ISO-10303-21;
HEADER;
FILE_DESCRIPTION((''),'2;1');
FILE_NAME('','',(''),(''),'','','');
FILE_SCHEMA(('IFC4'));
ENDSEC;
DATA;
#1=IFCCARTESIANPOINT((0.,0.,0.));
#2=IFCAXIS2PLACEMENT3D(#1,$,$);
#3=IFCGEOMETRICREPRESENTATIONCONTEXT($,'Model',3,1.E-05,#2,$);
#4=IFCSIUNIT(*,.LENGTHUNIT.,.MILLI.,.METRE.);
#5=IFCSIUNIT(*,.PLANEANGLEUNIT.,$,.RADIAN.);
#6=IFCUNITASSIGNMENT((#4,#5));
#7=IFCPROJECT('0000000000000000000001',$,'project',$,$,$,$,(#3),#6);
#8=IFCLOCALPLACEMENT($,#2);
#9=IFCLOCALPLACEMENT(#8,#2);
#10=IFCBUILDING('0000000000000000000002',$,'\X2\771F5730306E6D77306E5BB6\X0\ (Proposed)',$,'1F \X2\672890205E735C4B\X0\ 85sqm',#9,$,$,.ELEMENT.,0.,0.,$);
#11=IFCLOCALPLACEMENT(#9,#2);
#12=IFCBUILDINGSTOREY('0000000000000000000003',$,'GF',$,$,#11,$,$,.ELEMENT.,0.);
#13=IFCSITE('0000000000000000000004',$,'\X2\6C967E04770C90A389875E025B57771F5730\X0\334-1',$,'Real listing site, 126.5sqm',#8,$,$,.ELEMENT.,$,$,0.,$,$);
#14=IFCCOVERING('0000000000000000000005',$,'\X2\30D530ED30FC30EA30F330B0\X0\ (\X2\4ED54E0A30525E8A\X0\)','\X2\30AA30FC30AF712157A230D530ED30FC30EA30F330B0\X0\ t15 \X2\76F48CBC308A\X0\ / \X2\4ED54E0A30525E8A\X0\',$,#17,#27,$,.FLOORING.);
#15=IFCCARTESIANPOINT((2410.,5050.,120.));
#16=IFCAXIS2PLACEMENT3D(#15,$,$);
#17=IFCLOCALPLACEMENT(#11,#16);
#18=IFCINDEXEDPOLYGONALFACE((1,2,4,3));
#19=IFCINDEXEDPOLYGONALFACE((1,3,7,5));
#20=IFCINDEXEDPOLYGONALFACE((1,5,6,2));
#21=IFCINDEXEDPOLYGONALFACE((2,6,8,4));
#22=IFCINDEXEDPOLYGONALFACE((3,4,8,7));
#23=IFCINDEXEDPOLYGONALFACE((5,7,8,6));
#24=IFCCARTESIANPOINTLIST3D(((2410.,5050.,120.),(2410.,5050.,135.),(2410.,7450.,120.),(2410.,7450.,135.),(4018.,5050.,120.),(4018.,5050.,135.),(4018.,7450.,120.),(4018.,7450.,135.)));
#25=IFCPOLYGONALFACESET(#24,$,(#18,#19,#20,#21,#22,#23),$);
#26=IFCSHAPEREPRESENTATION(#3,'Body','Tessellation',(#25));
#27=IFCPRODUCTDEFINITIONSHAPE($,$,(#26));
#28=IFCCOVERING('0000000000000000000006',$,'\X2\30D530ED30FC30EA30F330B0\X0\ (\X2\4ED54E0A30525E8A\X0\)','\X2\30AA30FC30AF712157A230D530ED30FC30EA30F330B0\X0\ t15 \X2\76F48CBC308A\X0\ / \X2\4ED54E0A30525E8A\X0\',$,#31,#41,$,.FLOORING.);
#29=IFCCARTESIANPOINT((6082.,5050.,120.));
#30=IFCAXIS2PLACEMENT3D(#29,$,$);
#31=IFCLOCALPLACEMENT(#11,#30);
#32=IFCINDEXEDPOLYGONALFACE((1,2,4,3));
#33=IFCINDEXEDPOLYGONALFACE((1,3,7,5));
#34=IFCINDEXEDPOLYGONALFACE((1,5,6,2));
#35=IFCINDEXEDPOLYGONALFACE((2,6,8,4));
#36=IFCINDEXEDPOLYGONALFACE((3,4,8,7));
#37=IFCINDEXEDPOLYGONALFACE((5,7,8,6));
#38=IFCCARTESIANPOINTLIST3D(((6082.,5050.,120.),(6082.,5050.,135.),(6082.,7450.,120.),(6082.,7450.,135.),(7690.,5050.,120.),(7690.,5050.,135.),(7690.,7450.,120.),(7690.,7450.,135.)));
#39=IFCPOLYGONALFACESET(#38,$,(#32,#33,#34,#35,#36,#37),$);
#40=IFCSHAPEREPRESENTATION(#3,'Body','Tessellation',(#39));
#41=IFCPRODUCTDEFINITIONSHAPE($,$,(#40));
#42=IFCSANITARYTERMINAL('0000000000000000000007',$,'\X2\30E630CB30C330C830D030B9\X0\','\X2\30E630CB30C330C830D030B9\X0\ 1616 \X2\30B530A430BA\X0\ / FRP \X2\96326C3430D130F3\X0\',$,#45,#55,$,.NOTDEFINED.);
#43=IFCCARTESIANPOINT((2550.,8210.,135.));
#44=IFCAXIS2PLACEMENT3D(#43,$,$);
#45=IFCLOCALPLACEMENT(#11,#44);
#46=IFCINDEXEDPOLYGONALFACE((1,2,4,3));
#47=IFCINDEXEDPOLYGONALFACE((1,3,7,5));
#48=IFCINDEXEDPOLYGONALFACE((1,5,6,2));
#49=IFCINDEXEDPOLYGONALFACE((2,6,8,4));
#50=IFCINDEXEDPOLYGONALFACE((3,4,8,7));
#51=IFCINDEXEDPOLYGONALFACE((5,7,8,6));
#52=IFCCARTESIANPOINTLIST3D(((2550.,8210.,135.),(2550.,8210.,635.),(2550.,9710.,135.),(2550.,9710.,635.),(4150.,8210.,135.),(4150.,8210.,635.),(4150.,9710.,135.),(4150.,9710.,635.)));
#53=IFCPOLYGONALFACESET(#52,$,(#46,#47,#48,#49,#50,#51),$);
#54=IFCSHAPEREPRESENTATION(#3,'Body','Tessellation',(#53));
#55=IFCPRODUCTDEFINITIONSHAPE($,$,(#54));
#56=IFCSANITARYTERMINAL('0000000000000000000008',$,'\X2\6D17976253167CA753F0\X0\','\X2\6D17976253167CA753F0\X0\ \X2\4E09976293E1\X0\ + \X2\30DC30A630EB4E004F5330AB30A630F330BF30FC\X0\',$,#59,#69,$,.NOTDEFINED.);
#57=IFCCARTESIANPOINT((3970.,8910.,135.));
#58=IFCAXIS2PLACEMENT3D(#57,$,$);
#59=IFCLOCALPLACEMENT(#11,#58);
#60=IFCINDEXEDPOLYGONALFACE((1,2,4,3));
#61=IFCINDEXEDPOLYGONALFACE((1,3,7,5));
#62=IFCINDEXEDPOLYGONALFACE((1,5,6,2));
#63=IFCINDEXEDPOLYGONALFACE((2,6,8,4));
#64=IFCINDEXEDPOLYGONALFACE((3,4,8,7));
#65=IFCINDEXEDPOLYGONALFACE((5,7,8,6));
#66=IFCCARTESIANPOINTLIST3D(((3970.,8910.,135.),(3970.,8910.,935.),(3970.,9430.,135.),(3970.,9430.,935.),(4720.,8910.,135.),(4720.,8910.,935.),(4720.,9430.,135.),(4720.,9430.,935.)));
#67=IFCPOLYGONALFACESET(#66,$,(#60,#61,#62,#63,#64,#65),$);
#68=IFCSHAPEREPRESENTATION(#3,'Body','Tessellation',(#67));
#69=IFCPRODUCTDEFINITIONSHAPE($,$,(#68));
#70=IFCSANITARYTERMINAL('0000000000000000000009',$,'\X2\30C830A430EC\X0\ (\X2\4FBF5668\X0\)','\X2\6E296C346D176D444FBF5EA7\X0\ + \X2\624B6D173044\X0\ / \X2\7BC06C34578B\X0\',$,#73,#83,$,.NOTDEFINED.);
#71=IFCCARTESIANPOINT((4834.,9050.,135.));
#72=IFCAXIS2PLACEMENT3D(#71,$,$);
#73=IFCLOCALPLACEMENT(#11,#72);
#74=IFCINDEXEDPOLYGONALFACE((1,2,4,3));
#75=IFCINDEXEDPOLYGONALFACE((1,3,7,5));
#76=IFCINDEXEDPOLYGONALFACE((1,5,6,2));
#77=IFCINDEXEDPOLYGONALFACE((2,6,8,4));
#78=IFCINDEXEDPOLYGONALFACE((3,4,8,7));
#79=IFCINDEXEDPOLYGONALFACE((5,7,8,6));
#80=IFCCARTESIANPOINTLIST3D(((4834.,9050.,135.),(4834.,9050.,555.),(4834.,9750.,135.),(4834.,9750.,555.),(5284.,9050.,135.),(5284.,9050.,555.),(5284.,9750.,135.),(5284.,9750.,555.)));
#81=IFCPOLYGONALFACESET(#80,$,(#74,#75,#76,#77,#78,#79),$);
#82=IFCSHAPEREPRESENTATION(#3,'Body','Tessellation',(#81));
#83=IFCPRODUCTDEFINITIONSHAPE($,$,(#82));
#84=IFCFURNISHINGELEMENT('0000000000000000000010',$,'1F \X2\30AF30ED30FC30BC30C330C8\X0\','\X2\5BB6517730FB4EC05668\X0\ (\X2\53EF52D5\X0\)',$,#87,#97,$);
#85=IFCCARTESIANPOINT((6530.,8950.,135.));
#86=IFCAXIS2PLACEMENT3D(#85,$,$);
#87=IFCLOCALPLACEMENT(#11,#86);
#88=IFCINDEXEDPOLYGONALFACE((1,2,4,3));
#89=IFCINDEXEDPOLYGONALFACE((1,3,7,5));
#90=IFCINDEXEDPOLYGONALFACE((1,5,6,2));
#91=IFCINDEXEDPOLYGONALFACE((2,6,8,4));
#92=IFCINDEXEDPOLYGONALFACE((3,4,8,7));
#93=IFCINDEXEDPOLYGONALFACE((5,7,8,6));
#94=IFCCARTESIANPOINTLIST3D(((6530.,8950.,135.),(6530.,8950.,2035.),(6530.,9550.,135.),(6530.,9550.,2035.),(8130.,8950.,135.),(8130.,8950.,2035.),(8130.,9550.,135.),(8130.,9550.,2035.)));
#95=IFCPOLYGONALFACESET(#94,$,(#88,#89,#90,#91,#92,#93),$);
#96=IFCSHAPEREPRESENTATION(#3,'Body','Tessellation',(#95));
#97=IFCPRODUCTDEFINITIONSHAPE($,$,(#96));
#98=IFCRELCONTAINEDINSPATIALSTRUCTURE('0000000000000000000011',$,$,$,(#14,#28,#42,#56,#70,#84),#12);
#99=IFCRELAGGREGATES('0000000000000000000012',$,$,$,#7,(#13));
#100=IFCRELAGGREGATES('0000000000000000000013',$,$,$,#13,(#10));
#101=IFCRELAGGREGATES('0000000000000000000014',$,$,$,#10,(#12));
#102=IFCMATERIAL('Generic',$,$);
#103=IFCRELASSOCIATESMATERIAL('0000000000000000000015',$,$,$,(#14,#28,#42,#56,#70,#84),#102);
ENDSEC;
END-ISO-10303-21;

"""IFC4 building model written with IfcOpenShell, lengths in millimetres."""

from ifc_helpers import new_model, si_unit, frame, frame_2d, origin, place, context, project, spatial, rectangle, extrude, material, element, save


model = new_model("IFC4")

# Units and contexts
model_context = context("Model", 3, precision=1e-05, world=origin())
ifc_project = project(units=[si_unit("LENGTHUNIT", "METRE", prefix="MILLI"), si_unit("PLANEANGLEUNIT", "RADIAN")], contexts=[model_context])

# Site, building, storey
site_placement = place(None, origin())
site = spatial("IfcSite", under=ifc_project, at=site_placement, Name="沖縄県那覇市字真地334-1", ObjectType="Real listing site, 126.5sqm", CompositionType="ELEMENT", RefElevation=0.0)
building_placement = place(site_placement, origin())
building = spatial("IfcBuilding", under=site, at=building_placement, Name="真地の海の家 (Proposed)", ObjectType="1F 木造平屋 85sqm", CompositionType="ELEMENT", ElevationOfRefHeight=0.0, ElevationOfTerrain=0.0)
storey_placement = place(building_placement, origin())
storey = spatial("IfcBuildingStorey", under=building, at=storey_placement, Name="GF", CompositionType="ELEMENT", Elevation=0.0)

# Coverings
ifc_material_1 = material(Name="Generic")
covering_1_placement = place(storey_placement, frame((2410.0, 5050.0, 120.0)))
element("IfcCovering", 1, at=covering_1_placement, inside=storey, material=ifc_material_1, Name="フローリング (仕上げ床)", Description="オーク無垢フローリング t15 直貼り / 仕上げ床", PredefinedType="FLOORING", context=model_context, shape_type="SweptSolid", body=[
    extrude(rectangle(XDim=1608.0, YDim=2400.0, at=frame_2d((804.0, 1200.0))), frame((2410.0, 5050.0, 120.0)), (0.0, 0.0, 1.0), 15.0),
])
covering_2_placement = place(storey_placement, frame((6082.0, 5050.0, 120.0)))
element("IfcCovering", 2, at=covering_2_placement, inside=storey, material=ifc_material_1, Name="フローリング (仕上げ床)", Description="オーク無垢フローリング t15 直貼り / 仕上げ床", PredefinedType="FLOORING", context=model_context, shape_type="SweptSolid", body=[
    extrude(rectangle(XDim=1608.0, YDim=2400.0, at=frame_2d((804.0, 1200.0))), frame((6082.0, 5050.0, 120.0)), (0.0, 0.0, 1.0), 15.0),
])

# Sanitary terminals
sanitary_terminal_1_placement = place(storey_placement, frame((2550.0, 8210.0, 135.0)))
element("IfcSanitaryTerminal", 3, at=sanitary_terminal_1_placement, inside=storey, material=ifc_material_1, Name="ユニットバス", Description="ユニットバス 1616 サイズ / FRP 防水パン", PredefinedType="NOTDEFINED", context=model_context, shape_type="SweptSolid", body=[
    extrude(rectangle(XDim=1600.0, YDim=1500.0, at=frame_2d((800.0, 750.0))), frame((2550.0, 8210.0, 135.0)), (0.0, 0.0, 1.0), 500.0),
])
sanitary_terminal_2_placement = place(storey_placement, frame((3970.0, 8910.0, 135.0)))
element("IfcSanitaryTerminal", 4, at=sanitary_terminal_2_placement, inside=storey, material=ifc_material_1, Name="洗面化粧台", Description="洗面化粧台 三面鏡 + ボウル一体カウンター", PredefinedType="NOTDEFINED", context=model_context, shape_type="SweptSolid", body=[
    extrude(rectangle(XDim=750.0, YDim=520.0, at=frame_2d((375.0, 260.0))), frame((3970.0, 8910.0, 135.0)), (0.0, 0.0, 1.0), 800.0),
])
sanitary_terminal_3_placement = place(storey_placement, frame((4834.0, 9050.0, 135.0)))
element("IfcSanitaryTerminal", 5, at=sanitary_terminal_3_placement, inside=storey, material=ifc_material_1, Name="トイレ (便器)", Description="温水洗浄便座 + 手洗い / 節水型", PredefinedType="NOTDEFINED", context=model_context, shape_type="SweptSolid", body=[
    extrude(rectangle(XDim=450.0, YDim=700.0, at=frame_2d((225.0, 350.0))), frame((4834.0, 9050.0, 135.0)), (0.0, 0.0, 1.0), 420.0),
])

# Furnishing element
furnishing_placement = place(storey_placement, frame((6530.0, 8950.0, 135.0)))
element("IfcFurnishingElement", 6, at=furnishing_placement, inside=storey, material=ifc_material_1, Name="1F クローゼット", Description="家具・什器 (可動)", context=model_context, shape_type="SweptSolid", body=[
    extrude(rectangle(XDim=1600.0, YDim=600.0, at=frame_2d((800.0, 300.0))), frame((6530.0, 8950.0, 135.0)), (0.0, 0.0, 1.0), 1900.0),
])

save(model, "model.ifc")
